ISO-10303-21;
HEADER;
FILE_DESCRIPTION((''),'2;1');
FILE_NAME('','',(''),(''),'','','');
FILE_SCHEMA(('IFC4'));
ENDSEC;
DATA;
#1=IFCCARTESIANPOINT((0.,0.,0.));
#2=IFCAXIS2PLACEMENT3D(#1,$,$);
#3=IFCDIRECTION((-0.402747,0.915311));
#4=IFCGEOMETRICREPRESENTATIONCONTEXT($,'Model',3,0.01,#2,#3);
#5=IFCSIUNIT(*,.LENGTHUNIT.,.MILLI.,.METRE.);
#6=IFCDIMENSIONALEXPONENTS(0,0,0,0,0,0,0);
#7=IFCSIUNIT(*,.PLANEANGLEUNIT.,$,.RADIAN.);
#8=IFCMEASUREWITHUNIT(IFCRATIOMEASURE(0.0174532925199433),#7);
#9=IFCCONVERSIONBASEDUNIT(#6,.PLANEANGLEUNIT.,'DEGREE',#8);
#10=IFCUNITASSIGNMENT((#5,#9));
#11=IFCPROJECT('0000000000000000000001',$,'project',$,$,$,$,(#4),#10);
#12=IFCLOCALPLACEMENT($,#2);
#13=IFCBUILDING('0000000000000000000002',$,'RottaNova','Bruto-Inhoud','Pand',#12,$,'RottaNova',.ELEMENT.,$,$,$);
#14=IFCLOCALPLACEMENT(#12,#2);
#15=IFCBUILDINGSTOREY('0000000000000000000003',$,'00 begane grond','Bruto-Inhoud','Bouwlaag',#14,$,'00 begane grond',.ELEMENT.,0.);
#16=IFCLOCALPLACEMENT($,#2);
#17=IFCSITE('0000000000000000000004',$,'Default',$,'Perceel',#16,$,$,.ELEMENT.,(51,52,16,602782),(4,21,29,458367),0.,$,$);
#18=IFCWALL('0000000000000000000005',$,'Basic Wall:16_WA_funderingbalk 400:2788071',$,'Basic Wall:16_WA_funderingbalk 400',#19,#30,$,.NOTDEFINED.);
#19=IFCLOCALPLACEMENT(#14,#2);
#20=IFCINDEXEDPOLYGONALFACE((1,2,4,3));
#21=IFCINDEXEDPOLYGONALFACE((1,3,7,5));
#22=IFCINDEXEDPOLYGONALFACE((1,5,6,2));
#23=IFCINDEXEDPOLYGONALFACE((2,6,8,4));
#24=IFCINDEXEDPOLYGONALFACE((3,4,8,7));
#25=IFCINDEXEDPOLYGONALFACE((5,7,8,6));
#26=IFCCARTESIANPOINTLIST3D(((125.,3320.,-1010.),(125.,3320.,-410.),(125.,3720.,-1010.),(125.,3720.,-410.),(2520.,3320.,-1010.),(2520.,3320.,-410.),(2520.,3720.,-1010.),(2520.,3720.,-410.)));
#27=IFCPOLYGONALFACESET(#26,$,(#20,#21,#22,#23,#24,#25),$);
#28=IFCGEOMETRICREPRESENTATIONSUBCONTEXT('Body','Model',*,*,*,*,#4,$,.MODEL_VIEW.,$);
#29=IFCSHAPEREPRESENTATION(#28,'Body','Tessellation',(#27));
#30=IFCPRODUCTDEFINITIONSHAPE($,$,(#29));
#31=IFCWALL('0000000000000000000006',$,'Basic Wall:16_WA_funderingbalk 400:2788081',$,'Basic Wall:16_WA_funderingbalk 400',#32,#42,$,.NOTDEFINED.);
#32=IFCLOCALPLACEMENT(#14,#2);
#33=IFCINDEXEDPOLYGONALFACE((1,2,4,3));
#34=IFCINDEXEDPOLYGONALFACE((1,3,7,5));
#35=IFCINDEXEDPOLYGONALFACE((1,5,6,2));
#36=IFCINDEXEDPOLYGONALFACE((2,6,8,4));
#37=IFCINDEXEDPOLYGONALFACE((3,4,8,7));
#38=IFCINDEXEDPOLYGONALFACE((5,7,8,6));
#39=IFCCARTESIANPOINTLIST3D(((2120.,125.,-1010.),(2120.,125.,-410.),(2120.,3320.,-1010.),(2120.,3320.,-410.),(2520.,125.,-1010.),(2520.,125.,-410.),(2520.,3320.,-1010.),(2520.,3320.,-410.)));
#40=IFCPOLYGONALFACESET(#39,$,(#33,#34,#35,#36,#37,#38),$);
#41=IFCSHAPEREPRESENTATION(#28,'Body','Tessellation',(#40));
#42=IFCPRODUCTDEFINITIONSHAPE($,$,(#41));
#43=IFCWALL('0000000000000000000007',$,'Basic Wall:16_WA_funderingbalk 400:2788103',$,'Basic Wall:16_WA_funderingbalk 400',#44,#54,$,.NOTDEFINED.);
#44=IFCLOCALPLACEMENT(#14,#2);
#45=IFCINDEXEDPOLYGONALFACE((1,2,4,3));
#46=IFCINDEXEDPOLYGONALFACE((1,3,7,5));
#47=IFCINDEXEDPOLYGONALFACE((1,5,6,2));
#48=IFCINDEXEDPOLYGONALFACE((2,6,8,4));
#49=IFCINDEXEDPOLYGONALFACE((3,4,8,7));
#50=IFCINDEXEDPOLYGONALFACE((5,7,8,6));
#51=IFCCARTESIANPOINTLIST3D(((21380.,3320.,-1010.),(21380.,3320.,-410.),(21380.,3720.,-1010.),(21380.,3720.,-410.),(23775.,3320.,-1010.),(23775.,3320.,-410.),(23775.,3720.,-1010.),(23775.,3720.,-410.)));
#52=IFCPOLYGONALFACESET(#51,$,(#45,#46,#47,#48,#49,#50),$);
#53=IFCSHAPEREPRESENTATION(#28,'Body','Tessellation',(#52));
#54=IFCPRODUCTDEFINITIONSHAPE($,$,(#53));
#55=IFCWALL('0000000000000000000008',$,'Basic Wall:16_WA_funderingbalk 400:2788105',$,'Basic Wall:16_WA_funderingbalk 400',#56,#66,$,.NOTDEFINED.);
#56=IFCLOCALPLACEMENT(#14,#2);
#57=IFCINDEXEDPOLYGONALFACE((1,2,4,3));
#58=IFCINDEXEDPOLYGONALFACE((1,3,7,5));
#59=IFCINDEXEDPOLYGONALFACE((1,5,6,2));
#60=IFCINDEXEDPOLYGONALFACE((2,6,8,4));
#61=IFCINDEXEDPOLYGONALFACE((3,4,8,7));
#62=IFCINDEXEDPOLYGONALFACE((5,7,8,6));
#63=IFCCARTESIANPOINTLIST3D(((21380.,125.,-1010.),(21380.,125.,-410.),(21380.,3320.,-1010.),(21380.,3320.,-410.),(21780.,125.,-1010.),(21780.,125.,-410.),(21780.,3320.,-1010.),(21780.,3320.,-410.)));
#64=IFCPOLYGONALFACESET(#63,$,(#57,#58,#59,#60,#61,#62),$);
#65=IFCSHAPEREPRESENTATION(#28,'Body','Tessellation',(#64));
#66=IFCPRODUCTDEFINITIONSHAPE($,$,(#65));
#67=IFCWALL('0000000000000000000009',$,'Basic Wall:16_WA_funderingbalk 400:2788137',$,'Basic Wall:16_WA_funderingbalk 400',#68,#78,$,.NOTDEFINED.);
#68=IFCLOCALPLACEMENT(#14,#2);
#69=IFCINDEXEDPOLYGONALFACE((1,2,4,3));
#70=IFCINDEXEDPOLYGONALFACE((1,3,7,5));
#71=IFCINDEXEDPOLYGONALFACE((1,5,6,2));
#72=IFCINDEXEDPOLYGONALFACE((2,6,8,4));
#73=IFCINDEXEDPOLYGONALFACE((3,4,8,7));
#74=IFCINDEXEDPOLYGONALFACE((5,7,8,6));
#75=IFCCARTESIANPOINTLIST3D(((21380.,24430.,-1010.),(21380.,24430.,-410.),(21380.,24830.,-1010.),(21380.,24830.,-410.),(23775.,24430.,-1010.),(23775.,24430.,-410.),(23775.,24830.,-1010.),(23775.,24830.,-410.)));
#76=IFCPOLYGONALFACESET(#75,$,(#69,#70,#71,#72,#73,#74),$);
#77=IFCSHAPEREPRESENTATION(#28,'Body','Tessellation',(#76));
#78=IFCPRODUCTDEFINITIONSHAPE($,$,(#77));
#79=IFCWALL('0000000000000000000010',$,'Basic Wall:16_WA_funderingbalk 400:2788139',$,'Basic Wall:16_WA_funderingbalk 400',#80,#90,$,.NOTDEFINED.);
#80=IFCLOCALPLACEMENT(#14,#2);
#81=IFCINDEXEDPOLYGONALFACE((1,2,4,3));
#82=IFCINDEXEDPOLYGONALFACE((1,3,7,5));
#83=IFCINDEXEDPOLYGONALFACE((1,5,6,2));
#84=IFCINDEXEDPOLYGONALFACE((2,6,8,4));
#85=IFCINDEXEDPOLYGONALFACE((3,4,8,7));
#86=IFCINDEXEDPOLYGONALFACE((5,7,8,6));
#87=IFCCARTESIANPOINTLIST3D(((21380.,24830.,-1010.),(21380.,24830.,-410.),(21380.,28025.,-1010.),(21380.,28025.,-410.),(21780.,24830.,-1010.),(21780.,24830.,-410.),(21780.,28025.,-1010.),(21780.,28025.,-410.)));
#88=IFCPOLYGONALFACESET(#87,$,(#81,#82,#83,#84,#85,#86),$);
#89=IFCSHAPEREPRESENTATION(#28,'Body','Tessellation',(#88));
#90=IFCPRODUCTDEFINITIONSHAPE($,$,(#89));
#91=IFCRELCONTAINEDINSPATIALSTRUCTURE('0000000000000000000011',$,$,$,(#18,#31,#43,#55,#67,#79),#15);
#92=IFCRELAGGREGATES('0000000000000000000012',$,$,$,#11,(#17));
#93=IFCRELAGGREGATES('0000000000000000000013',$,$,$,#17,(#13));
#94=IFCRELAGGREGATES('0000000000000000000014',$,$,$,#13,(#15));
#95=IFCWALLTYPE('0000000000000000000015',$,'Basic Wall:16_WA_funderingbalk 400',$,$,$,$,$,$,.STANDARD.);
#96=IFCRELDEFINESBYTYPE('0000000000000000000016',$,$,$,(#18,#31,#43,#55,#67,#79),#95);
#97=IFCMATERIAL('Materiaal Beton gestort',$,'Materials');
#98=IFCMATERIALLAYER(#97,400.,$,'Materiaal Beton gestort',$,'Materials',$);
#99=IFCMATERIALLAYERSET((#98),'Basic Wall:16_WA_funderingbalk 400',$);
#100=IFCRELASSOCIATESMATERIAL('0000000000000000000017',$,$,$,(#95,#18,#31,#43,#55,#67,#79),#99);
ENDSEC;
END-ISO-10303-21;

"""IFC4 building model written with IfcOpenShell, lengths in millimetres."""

from ifc_helpers import new_model, entity, si_unit, converted_unit, direction, frame, frame_2d, origin, place, context, subcontext, project, spatial, rectangle, extrude, material, layer, layer_set, type_object, element, save


model = new_model("IFC4")

# Units and contexts
model_context = context("Model", 3, precision=0.01, world=origin(), true_north=direction((-0.402747, 0.915311)))
body_context = subcontext(model_context, "Body", "Model", "MODEL_VIEW")
ifc_project = project(units=[si_unit("LENGTHUNIT", "METRE", prefix="MILLI"), converted_unit("PLANEANGLEUNIT", "DEGREE", entity("IfcRatioMeasure", 0.0174532925199433), si_unit("PLANEANGLEUNIT", "RADIAN"), dimensions=[0, 0, 0, 0, 0, 0, 0])], contexts=[model_context])

# Site, building, storey
site_placement = place(None, origin())
site = spatial("IfcSite", under=ifc_project, at=site_placement, Name="Default", ObjectType="Perceel", CompositionType="ELEMENT", RefLatitude=(51, 52, 16, 602782), RefLongitude=(4, 21, 29, 458367), RefElevation=0.0)
building_placement = place(None, origin())
building = spatial("IfcBuilding", under=site, at=building_placement, Name="RottaNova", Description="Bruto-Inhoud", ObjectType="Pand", LongName="RottaNova", CompositionType="ELEMENT")
storey_placement = place(building_placement, origin())
storey = spatial("IfcBuildingStorey", under=building, at=storey_placement, Name="00 begane grond", Description="Bruto-Inhoud", ObjectType="Bouwlaag", LongName="00 begane grond", CompositionType="ELEMENT", Elevation=0.0)

# Walls
ifc_material_1 = material(Name="Materiaal Beton gestort", Category="Materials")
ifc_layer_1 = layer(ifc_material_1, 400.0, Name="Materiaal Beton gestort", Category="Materials")
ifc_layer_set_1 = layer_set([ifc_layer_1], Name="Basic Wall:16_WA_funderingbalk 400")
wall_type_1 = type_object("IfcWallType", Name="Basic Wall:16_WA_funderingbalk 400", PredefinedType="STANDARD", material=ifc_layer_set_1)
wall_1_placement = place(storey_placement, frame((125.0, 3520.0, -1010.0)))
element("IfcWall", 1, at=wall_1_placement, inside=storey, type_object=wall_type_1, material=ifc_layer_set_1, Name="Basic Wall:16_WA_funderingbalk 400:2788071", ObjectType="Basic Wall:16_WA_funderingbalk 400", PredefinedType="NOTDEFINED", context=body_context, shape_type="SweptSolid", body=[
    extrude(rectangle(XDim=2395.0, YDim=400.0, at=frame_2d((1197.5, 0.0), x_axis=(-1.0, 0.0))), origin(), (0.0, 0.0, 1.0), 600.0),
])
wall_2_placement = place(storey_placement, frame((2320.0, 125.0, -1010.0), z_axis=(0.0, 0.0, 1.0), x_axis=(0.0, 1.0, 0.0)))
element("IfcWall", 2, at=wall_2_placement, inside=storey, type_object=wall_type_1, material=ifc_layer_set_1, Name="Basic Wall:16_WA_funderingbalk 400:2788081", ObjectType="Basic Wall:16_WA_funderingbalk 400", PredefinedType="NOTDEFINED", context=body_context, shape_type="SweptSolid", body=[
    extrude(rectangle(XDim=3195.0, YDim=400.0, at=frame_2d((1597.5, 0.0), x_axis=(-1.0, 0.0))), origin(), (0.0, 0.0, 1.0), 600.0),
])
wall_3_placement = place(storey_placement, frame((21380.0, 3520.0, -1010.0)))
element("IfcWall", 3, at=wall_3_placement, inside=storey, type_object=wall_type_1, material=ifc_layer_set_1, Name="Basic Wall:16_WA_funderingbalk 400:2788103", ObjectType="Basic Wall:16_WA_funderingbalk 400", PredefinedType="NOTDEFINED", context=body_context, shape_type="SweptSolid", body=[
    extrude(rectangle(XDim=2395.0, YDim=400.0, at=frame_2d((1197.5, 0.0), x_axis=(-1.0, 0.0))), origin(), (0.0, 0.0, 1.0), 600.0),
])
wall_4_placement = place(storey_placement, frame((21580.0, 125.0, -1010.0), z_axis=(0.0, 0.0, 1.0), x_axis=(0.0, 1.0, 0.0)))
element("IfcWall", 4, at=wall_4_placement, inside=storey, type_object=wall_type_1, material=ifc_layer_set_1, Name="Basic Wall:16_WA_funderingbalk 400:2788105", ObjectType="Basic Wall:16_WA_funderingbalk 400", PredefinedType="NOTDEFINED", context=body_context, shape_type="SweptSolid", body=[
    extrude(rectangle(XDim=3195.0, YDim=400.0, at=frame_2d((1597.5, 0.0), x_axis=(-1.0, 0.0))), origin(), (0.0, 0.0, 1.0), 600.0),
])
wall_5_placement = place(storey_placement, frame((21380.0, 24630.0, -1010.0)))
element("IfcWall", 5, at=wall_5_placement, inside=storey, type_object=wall_type_1, material=ifc_layer_set_1, Name="Basic Wall:16_WA_funderingbalk 400:2788137", ObjectType="Basic Wall:16_WA_funderingbalk 400", PredefinedType="NOTDEFINED", context=body_context, shape_type="SweptSolid", body=[
    extrude(rectangle(XDim=2395.0, YDim=400.0, at=frame_2d((1197.5, 0.0), x_axis=(-1.0, 0.0))), origin(), (0.0, 0.0, 1.0), 600.0),
])
wall_6_placement = place(storey_placement, frame((21580.0, 28025.0, -1010.0), z_axis=(0.0, 0.0, 1.0), x_axis=(0.0, -1.0, 0.0)))
element("IfcWall", 6, at=wall_6_placement, inside=storey, type_object=wall_type_1, material=ifc_layer_set_1, Name="Basic Wall:16_WA_funderingbalk 400:2788139", ObjectType="Basic Wall:16_WA_funderingbalk 400", PredefinedType="NOTDEFINED", context=body_context, shape_type="SweptSolid", body=[
    extrude(rectangle(XDim=3195.0, YDim=400.0, at=frame_2d((1597.5, 0.0), x_axis=(-1.0, 0.0))), origin(), (0.0, 0.0, 1.0), 600.0),
])

save(model, "model.ifc")
